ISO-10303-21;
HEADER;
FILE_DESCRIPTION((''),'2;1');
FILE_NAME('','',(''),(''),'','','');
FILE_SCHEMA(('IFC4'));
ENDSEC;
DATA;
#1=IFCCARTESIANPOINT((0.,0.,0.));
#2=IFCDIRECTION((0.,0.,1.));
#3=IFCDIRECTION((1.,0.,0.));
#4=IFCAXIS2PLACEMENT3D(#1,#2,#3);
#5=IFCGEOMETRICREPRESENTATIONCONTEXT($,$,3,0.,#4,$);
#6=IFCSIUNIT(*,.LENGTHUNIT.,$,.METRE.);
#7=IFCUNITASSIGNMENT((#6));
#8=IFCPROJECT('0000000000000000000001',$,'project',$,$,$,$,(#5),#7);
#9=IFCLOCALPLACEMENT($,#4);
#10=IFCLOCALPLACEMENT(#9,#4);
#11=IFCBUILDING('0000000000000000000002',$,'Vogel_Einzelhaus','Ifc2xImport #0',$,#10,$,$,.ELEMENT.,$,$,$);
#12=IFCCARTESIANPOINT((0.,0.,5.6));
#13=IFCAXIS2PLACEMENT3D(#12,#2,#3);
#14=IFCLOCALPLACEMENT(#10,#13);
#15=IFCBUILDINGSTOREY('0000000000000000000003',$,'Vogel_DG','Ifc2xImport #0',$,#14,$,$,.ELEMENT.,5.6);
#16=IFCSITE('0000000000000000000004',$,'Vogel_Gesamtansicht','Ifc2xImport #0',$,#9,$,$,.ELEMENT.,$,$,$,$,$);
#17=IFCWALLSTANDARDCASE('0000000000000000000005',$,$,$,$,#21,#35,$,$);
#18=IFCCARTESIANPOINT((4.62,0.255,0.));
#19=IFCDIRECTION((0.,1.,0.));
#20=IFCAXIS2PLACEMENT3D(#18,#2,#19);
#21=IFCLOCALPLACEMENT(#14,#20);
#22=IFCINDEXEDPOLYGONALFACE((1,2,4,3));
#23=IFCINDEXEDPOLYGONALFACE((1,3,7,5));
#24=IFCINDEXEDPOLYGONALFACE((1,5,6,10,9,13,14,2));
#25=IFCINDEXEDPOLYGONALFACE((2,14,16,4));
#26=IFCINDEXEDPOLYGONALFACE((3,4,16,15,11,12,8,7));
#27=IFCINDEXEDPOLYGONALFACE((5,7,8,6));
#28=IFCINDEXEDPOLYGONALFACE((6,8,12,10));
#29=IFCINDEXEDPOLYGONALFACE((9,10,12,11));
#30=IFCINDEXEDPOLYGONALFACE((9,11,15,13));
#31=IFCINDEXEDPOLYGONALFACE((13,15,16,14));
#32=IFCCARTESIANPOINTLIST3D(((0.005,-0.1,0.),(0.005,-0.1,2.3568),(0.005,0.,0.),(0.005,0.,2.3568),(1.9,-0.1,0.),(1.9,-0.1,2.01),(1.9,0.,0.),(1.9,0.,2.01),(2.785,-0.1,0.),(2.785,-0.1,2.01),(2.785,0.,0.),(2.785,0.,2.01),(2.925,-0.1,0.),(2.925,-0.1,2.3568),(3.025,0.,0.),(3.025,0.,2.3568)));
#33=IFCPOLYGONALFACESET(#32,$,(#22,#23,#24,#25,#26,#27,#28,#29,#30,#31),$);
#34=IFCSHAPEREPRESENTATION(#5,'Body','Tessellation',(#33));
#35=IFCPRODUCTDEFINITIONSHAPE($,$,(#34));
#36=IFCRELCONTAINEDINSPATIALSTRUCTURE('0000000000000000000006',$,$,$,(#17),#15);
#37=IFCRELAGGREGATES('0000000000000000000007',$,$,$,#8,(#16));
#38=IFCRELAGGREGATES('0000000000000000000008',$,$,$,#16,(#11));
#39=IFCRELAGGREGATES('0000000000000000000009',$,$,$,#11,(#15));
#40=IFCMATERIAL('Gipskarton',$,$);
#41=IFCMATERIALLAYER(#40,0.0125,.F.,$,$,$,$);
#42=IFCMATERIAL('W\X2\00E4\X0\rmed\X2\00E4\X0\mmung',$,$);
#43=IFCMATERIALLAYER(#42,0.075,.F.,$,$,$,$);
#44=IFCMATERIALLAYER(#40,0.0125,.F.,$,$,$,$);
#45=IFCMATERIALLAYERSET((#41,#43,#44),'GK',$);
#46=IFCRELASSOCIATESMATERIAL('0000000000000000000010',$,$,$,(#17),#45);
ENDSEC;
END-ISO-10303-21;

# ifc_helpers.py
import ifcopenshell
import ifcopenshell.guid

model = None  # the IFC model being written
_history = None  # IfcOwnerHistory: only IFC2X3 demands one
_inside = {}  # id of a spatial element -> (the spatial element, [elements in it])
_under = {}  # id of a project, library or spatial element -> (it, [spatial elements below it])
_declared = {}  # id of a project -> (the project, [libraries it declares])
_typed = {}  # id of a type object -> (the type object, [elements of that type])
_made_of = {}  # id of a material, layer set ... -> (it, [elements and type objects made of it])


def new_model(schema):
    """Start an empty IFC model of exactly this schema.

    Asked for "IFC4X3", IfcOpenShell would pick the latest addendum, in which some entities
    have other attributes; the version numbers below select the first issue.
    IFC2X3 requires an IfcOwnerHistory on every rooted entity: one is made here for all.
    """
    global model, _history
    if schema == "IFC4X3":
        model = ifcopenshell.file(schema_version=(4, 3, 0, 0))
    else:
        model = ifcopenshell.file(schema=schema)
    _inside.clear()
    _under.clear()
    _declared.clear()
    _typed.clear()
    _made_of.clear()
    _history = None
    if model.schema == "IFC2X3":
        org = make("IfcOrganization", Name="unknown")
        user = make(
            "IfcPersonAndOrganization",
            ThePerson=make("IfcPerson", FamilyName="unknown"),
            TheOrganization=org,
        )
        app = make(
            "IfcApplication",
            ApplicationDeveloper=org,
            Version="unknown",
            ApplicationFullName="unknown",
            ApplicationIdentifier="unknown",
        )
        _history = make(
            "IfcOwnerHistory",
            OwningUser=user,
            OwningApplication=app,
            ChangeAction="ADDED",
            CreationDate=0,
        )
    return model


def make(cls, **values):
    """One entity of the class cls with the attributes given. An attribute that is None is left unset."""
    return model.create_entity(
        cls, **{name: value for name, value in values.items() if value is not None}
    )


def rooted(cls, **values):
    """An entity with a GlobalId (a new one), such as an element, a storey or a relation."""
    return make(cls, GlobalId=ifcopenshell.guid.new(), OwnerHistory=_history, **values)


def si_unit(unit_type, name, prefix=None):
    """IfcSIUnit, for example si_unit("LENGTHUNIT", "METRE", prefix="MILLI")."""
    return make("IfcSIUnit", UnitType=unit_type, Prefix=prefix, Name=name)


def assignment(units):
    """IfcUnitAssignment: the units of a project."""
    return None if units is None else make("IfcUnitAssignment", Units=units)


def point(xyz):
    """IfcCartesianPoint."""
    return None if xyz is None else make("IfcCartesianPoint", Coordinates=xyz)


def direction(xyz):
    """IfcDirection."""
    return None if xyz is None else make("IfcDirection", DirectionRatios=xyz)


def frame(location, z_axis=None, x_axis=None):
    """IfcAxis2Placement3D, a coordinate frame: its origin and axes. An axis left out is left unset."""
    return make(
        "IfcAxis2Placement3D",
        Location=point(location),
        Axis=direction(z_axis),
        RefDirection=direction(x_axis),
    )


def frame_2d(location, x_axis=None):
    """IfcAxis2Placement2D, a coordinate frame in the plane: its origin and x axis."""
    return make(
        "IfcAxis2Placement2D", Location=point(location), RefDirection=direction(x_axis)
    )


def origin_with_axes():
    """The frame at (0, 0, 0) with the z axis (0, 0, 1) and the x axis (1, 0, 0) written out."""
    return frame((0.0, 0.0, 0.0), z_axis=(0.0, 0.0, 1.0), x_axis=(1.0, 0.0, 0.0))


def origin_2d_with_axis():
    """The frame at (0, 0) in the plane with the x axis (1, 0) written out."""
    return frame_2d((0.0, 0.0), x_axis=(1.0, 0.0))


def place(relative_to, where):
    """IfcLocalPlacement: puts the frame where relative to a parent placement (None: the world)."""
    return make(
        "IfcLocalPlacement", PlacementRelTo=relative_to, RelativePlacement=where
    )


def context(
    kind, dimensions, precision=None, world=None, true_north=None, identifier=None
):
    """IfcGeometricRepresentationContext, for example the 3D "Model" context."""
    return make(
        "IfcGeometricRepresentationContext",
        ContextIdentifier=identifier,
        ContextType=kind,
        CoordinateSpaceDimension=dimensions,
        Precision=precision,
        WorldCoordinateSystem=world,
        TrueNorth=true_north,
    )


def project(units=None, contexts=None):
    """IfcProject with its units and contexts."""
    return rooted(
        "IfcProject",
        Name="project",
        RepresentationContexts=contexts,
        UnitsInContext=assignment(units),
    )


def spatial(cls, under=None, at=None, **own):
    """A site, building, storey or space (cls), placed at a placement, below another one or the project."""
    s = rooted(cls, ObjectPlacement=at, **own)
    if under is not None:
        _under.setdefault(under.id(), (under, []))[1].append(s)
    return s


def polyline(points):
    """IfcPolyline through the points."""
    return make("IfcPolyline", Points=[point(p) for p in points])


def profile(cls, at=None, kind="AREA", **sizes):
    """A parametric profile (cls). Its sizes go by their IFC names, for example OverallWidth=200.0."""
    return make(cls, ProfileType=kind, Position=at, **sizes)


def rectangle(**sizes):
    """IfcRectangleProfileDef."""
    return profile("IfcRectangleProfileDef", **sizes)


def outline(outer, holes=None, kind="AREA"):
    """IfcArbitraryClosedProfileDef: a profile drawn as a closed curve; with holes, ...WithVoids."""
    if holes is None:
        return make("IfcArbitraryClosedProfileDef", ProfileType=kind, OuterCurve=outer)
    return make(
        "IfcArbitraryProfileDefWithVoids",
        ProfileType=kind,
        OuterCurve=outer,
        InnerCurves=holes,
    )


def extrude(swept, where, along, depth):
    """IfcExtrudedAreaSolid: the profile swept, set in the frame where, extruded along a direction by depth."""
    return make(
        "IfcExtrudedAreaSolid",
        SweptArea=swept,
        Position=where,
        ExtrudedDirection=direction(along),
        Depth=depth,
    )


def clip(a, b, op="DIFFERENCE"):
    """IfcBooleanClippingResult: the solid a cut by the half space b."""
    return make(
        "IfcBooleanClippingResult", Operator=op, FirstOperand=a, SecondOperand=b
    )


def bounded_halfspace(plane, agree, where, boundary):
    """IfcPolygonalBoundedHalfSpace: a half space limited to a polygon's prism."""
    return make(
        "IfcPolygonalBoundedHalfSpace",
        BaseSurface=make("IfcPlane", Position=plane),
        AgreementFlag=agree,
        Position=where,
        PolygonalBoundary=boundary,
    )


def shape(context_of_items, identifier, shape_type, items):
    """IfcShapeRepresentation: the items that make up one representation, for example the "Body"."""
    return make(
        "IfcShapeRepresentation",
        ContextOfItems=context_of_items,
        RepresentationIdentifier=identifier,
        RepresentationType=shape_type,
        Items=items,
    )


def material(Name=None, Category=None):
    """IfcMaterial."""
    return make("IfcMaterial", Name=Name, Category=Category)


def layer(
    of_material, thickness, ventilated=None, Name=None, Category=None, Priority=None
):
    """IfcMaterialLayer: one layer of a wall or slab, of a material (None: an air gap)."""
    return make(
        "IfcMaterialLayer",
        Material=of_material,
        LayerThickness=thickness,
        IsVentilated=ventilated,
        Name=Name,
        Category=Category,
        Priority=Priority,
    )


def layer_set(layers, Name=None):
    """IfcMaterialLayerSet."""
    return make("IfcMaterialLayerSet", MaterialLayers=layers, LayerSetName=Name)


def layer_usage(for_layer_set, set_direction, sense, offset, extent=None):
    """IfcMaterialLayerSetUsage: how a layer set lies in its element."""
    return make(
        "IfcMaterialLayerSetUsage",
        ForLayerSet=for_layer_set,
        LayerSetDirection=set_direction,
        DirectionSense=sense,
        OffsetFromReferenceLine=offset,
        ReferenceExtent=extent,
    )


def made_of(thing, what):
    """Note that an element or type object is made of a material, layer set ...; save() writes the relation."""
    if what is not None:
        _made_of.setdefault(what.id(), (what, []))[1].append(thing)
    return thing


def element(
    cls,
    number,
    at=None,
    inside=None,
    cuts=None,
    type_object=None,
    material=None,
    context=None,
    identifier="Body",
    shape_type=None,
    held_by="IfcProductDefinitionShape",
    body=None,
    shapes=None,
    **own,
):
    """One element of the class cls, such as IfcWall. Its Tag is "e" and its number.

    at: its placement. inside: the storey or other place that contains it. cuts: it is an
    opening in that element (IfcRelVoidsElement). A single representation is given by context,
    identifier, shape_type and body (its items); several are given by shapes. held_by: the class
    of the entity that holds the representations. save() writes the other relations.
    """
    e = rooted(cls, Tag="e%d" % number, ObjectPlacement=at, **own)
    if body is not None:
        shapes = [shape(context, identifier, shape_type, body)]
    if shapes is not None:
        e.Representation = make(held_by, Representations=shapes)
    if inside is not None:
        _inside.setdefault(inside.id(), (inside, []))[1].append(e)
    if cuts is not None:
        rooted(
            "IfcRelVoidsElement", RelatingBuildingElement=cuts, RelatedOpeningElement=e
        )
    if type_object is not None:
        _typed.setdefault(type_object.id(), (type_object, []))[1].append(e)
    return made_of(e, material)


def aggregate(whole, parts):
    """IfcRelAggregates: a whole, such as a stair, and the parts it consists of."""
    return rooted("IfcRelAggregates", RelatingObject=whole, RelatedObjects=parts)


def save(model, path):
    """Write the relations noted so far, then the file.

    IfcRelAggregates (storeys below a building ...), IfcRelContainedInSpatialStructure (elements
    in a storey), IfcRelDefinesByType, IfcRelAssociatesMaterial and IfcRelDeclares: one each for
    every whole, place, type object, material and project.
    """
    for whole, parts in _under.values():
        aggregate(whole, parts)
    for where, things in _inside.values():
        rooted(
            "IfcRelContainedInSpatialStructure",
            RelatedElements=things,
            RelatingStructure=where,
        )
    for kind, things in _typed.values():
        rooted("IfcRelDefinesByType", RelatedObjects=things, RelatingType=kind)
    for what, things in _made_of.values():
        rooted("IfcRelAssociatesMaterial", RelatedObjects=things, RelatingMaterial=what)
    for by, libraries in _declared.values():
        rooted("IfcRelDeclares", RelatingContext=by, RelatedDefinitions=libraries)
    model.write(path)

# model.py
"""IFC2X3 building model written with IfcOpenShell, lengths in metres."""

from ifc_helpers import new_model, si_unit, frame, origin_with_axes, origin_2d_with_axis, place, context, project, spatial, polyline, rectangle, outline, extrude, clip, bounded_halfspace, shape, material, layer, layer_set, layer_usage, element, save


model = new_model("IFC2X3")

# Units and contexts
context_of_model = context(None, 3, precision=0.0, world=origin_with_axes())
ifc_project = project(units=[si_unit("LENGTHUNIT", "METRE")], contexts=[context_of_model])

# Site, building, storey
site_placement = place(None, origin_with_axes())
site = spatial("IfcSite", under=ifc_project, at=site_placement, Name="Vogel_Gesamtansicht", Description="Ifc2xImport #0", CompositionType="ELEMENT")
building_placement = place(site_placement, origin_with_axes())
building = spatial("IfcBuilding", under=site, at=building_placement, Name="Vogel_Einzelhaus", Description="Ifc2xImport #0", CompositionType="ELEMENT")
storey_placement = place(building_placement, frame((0.0, 0.0, 5.6), z_axis=(0.0, 0.0, 1.0), x_axis=(1.0, 0.0, 0.0)))
storey = spatial("IfcBuildingStorey", under=building, at=storey_placement, Name="Vogel_DG", Description="Ifc2xImport #0", CompositionType="ELEMENT", Elevation=5.6)

# Shared definitions
ifc_material_1 = material(Name="Gipskarton")
ifc_layer_1 = layer(ifc_material_1, 0.0125, ventilated=False)
ifc_material_2 = material(Name="Wärmedämmung")
ifc_layer_2 = layer(ifc_material_2, 0.075, ventilated=False)
ifc_layer_3 = layer(ifc_material_1, 0.0125, ventilated=False)
ifc_layer_set_1 = layer_set([ifc_layer_1, ifc_layer_2, ifc_layer_3], Name="GK")
ifc_layer_usage_1 = layer_usage(ifc_layer_set_1, "AXIS2", "POSITIVE", -0.1)

# Wall, opening
wall_1_placement = place(storey_placement, frame((4.62, 0.255, 0.0), z_axis=(0.0, 0.0, 1.0), x_axis=(0.0, 1.0, 0.0)))
wall_1 = element("IfcWallStandardCase", 1, at=wall_1_placement, inside=storey, material=ifc_layer_usage_1, context=context_of_model, shape_type="Clipping", body=[
    clip(extrude(outline(polyline([(2.925, -0.1), (3.025, 0.0), (0.005, 0.0), (0.005, -0.1), (2.925, -0.1)])), origin_with_axes(), (0.0, 0.0, 1.0), 2.3568), bounded_halfspace(frame((0.0, 0.0, 2.3568), z_axis=(0.0, 0.0, -1.0), x_axis=(1.0, 0.0, 0.0)), True, origin_with_axes(), polyline([(-2.91, -0.1), (2.91, -0.1), (2.91, 0.1), (-2.91, 0.1), (-2.91, -0.1)]))),
])
opening_1_placement = place(wall_1_placement, frame((2.785, -0.1, 0.0), z_axis=(-1.0, 0.0, 0.0), x_axis=(0.0, 0.0, 1.0)))
element("IfcOpeningElement", 2, at=opening_1_placement, cuts=wall_1, shapes=[
    shape(context_of_model, None, "SweptSolid", [extrude(rectangle(XDim=2.01, YDim=0.885, at=origin_2d_with_axis()), frame((1.005, 0.0, 0.4425), z_axis=(0.0, 1.0, 0.0), x_axis=(1.0, 0.0, 0.0)), (0.0, 0.0, 1.0), 0.1)]),
])

save(model, "model.ifc")
